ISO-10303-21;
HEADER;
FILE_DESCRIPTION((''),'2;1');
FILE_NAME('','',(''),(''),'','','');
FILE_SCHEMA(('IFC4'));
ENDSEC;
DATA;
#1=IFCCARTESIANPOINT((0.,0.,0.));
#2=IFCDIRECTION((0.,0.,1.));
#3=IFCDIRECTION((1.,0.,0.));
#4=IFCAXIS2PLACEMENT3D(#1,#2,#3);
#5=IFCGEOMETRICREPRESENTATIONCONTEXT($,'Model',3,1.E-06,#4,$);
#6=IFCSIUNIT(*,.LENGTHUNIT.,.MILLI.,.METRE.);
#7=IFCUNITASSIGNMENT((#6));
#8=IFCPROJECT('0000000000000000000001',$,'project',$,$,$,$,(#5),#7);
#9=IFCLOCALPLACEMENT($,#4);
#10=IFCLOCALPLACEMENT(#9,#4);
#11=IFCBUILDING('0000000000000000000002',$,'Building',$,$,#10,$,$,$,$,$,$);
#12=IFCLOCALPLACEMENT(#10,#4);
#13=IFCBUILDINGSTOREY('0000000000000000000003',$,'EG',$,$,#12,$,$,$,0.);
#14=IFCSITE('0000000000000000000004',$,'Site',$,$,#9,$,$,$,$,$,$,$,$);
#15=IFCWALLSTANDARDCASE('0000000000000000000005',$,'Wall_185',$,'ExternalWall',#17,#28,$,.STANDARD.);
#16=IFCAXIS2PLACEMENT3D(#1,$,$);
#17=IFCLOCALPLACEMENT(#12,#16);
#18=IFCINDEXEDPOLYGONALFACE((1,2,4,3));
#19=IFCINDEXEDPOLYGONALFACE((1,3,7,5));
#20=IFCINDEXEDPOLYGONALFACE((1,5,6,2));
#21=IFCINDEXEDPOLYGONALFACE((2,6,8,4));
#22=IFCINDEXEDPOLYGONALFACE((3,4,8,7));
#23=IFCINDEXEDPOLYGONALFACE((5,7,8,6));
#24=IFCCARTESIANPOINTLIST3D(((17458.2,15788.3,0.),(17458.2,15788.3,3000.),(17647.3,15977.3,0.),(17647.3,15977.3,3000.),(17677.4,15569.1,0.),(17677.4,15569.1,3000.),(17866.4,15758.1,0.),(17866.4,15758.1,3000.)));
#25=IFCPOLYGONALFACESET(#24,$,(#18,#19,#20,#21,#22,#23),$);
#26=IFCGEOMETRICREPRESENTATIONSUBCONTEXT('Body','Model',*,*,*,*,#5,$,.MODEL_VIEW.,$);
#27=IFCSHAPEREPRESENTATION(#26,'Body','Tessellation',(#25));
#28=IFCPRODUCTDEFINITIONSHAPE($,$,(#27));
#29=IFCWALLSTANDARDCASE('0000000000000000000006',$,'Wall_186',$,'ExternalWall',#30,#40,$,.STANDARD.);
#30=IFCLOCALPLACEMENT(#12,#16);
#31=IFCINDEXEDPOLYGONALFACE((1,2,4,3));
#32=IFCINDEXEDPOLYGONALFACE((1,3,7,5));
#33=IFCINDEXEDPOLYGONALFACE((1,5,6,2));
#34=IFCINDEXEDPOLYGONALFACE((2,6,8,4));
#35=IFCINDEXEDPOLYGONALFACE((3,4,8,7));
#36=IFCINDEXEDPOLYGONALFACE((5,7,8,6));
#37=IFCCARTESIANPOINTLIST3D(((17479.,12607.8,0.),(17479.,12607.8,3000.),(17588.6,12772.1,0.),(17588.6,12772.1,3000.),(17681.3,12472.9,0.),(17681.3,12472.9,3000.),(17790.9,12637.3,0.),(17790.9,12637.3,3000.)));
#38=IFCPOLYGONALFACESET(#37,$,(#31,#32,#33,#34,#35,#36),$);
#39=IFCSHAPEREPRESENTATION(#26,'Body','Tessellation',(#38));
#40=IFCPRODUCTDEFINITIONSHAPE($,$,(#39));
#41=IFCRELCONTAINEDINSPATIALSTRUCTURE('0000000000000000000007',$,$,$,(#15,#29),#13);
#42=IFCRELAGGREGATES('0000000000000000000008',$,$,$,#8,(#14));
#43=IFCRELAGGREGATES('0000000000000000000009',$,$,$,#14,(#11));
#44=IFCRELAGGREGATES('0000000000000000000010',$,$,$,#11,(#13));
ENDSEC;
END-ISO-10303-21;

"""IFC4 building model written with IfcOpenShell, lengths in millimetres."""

from ifc_helpers import new_model, si_unit, frame, origin_with_axes, place, context, subcontext, project, spatial, rectangle, extrude, element, save


model = new_model("IFC4")

# Units and contexts
model_context = context("Model", 3, precision=1e-06, world=origin_with_axes())
body_context = subcontext(model_context, "Body", "Model", "MODEL_VIEW")
ifc_project = project(units=[si_unit("LENGTHUNIT", "METRE", prefix="MILLI")], contexts=[model_context])

# Site, building, storey
site_placement = place(None, origin_with_axes())
site = spatial("IfcSite", under=ifc_project, at=site_placement, Name="Site")
building_placement = place(site_placement, origin_with_axes())
building = spatial("IfcBuilding", under=site, at=building_placement, Name="Building")
storey_placement = place(building_placement, origin_with_axes())
storey = spatial("IfcBuildingStorey", under=building, at=storey_placement, Name="EG", Elevation=0.0)

# Walls
wall_1_placement = place(storey_placement, origin_with_axes())
element("IfcWallStandardCase", 1, at=wall_1_placement, inside=storey, Name="Wall_185", ObjectType="ExternalWall", PredefinedType="STANDARD", context=body_context, shape_type="SweptSolid", body=[
    extrude(rectangle(XDim=310.0, YDim=267.4), frame((17662.3, 15773.2, 0.0), z_axis=(0.0, 0.0, 1.0), x_axis=(-0.707107, 0.707107, 0.0)), (0.0, 0.0, 1.0), 3000.0),
])
wall_2_placement = place(storey_placement, origin_with_axes())
element("IfcWallStandardCase", 2, at=wall_2_placement, inside=storey, Name="Wall_186", ObjectType="ExternalWall", PredefinedType="STANDARD", context=body_context, shape_type="SweptSolid", body=[
    extrude(rectangle(XDim=197.6, YDim=243.1), frame((17634.9, 12622.5, 0.0), z_axis=(0.0, 0.0, 1.0), x_axis=(-0.5547, -0.83205, 0.0)), (0.0, 0.0, 1.0), 3000.0),
])

save(model, "model.ifc")
